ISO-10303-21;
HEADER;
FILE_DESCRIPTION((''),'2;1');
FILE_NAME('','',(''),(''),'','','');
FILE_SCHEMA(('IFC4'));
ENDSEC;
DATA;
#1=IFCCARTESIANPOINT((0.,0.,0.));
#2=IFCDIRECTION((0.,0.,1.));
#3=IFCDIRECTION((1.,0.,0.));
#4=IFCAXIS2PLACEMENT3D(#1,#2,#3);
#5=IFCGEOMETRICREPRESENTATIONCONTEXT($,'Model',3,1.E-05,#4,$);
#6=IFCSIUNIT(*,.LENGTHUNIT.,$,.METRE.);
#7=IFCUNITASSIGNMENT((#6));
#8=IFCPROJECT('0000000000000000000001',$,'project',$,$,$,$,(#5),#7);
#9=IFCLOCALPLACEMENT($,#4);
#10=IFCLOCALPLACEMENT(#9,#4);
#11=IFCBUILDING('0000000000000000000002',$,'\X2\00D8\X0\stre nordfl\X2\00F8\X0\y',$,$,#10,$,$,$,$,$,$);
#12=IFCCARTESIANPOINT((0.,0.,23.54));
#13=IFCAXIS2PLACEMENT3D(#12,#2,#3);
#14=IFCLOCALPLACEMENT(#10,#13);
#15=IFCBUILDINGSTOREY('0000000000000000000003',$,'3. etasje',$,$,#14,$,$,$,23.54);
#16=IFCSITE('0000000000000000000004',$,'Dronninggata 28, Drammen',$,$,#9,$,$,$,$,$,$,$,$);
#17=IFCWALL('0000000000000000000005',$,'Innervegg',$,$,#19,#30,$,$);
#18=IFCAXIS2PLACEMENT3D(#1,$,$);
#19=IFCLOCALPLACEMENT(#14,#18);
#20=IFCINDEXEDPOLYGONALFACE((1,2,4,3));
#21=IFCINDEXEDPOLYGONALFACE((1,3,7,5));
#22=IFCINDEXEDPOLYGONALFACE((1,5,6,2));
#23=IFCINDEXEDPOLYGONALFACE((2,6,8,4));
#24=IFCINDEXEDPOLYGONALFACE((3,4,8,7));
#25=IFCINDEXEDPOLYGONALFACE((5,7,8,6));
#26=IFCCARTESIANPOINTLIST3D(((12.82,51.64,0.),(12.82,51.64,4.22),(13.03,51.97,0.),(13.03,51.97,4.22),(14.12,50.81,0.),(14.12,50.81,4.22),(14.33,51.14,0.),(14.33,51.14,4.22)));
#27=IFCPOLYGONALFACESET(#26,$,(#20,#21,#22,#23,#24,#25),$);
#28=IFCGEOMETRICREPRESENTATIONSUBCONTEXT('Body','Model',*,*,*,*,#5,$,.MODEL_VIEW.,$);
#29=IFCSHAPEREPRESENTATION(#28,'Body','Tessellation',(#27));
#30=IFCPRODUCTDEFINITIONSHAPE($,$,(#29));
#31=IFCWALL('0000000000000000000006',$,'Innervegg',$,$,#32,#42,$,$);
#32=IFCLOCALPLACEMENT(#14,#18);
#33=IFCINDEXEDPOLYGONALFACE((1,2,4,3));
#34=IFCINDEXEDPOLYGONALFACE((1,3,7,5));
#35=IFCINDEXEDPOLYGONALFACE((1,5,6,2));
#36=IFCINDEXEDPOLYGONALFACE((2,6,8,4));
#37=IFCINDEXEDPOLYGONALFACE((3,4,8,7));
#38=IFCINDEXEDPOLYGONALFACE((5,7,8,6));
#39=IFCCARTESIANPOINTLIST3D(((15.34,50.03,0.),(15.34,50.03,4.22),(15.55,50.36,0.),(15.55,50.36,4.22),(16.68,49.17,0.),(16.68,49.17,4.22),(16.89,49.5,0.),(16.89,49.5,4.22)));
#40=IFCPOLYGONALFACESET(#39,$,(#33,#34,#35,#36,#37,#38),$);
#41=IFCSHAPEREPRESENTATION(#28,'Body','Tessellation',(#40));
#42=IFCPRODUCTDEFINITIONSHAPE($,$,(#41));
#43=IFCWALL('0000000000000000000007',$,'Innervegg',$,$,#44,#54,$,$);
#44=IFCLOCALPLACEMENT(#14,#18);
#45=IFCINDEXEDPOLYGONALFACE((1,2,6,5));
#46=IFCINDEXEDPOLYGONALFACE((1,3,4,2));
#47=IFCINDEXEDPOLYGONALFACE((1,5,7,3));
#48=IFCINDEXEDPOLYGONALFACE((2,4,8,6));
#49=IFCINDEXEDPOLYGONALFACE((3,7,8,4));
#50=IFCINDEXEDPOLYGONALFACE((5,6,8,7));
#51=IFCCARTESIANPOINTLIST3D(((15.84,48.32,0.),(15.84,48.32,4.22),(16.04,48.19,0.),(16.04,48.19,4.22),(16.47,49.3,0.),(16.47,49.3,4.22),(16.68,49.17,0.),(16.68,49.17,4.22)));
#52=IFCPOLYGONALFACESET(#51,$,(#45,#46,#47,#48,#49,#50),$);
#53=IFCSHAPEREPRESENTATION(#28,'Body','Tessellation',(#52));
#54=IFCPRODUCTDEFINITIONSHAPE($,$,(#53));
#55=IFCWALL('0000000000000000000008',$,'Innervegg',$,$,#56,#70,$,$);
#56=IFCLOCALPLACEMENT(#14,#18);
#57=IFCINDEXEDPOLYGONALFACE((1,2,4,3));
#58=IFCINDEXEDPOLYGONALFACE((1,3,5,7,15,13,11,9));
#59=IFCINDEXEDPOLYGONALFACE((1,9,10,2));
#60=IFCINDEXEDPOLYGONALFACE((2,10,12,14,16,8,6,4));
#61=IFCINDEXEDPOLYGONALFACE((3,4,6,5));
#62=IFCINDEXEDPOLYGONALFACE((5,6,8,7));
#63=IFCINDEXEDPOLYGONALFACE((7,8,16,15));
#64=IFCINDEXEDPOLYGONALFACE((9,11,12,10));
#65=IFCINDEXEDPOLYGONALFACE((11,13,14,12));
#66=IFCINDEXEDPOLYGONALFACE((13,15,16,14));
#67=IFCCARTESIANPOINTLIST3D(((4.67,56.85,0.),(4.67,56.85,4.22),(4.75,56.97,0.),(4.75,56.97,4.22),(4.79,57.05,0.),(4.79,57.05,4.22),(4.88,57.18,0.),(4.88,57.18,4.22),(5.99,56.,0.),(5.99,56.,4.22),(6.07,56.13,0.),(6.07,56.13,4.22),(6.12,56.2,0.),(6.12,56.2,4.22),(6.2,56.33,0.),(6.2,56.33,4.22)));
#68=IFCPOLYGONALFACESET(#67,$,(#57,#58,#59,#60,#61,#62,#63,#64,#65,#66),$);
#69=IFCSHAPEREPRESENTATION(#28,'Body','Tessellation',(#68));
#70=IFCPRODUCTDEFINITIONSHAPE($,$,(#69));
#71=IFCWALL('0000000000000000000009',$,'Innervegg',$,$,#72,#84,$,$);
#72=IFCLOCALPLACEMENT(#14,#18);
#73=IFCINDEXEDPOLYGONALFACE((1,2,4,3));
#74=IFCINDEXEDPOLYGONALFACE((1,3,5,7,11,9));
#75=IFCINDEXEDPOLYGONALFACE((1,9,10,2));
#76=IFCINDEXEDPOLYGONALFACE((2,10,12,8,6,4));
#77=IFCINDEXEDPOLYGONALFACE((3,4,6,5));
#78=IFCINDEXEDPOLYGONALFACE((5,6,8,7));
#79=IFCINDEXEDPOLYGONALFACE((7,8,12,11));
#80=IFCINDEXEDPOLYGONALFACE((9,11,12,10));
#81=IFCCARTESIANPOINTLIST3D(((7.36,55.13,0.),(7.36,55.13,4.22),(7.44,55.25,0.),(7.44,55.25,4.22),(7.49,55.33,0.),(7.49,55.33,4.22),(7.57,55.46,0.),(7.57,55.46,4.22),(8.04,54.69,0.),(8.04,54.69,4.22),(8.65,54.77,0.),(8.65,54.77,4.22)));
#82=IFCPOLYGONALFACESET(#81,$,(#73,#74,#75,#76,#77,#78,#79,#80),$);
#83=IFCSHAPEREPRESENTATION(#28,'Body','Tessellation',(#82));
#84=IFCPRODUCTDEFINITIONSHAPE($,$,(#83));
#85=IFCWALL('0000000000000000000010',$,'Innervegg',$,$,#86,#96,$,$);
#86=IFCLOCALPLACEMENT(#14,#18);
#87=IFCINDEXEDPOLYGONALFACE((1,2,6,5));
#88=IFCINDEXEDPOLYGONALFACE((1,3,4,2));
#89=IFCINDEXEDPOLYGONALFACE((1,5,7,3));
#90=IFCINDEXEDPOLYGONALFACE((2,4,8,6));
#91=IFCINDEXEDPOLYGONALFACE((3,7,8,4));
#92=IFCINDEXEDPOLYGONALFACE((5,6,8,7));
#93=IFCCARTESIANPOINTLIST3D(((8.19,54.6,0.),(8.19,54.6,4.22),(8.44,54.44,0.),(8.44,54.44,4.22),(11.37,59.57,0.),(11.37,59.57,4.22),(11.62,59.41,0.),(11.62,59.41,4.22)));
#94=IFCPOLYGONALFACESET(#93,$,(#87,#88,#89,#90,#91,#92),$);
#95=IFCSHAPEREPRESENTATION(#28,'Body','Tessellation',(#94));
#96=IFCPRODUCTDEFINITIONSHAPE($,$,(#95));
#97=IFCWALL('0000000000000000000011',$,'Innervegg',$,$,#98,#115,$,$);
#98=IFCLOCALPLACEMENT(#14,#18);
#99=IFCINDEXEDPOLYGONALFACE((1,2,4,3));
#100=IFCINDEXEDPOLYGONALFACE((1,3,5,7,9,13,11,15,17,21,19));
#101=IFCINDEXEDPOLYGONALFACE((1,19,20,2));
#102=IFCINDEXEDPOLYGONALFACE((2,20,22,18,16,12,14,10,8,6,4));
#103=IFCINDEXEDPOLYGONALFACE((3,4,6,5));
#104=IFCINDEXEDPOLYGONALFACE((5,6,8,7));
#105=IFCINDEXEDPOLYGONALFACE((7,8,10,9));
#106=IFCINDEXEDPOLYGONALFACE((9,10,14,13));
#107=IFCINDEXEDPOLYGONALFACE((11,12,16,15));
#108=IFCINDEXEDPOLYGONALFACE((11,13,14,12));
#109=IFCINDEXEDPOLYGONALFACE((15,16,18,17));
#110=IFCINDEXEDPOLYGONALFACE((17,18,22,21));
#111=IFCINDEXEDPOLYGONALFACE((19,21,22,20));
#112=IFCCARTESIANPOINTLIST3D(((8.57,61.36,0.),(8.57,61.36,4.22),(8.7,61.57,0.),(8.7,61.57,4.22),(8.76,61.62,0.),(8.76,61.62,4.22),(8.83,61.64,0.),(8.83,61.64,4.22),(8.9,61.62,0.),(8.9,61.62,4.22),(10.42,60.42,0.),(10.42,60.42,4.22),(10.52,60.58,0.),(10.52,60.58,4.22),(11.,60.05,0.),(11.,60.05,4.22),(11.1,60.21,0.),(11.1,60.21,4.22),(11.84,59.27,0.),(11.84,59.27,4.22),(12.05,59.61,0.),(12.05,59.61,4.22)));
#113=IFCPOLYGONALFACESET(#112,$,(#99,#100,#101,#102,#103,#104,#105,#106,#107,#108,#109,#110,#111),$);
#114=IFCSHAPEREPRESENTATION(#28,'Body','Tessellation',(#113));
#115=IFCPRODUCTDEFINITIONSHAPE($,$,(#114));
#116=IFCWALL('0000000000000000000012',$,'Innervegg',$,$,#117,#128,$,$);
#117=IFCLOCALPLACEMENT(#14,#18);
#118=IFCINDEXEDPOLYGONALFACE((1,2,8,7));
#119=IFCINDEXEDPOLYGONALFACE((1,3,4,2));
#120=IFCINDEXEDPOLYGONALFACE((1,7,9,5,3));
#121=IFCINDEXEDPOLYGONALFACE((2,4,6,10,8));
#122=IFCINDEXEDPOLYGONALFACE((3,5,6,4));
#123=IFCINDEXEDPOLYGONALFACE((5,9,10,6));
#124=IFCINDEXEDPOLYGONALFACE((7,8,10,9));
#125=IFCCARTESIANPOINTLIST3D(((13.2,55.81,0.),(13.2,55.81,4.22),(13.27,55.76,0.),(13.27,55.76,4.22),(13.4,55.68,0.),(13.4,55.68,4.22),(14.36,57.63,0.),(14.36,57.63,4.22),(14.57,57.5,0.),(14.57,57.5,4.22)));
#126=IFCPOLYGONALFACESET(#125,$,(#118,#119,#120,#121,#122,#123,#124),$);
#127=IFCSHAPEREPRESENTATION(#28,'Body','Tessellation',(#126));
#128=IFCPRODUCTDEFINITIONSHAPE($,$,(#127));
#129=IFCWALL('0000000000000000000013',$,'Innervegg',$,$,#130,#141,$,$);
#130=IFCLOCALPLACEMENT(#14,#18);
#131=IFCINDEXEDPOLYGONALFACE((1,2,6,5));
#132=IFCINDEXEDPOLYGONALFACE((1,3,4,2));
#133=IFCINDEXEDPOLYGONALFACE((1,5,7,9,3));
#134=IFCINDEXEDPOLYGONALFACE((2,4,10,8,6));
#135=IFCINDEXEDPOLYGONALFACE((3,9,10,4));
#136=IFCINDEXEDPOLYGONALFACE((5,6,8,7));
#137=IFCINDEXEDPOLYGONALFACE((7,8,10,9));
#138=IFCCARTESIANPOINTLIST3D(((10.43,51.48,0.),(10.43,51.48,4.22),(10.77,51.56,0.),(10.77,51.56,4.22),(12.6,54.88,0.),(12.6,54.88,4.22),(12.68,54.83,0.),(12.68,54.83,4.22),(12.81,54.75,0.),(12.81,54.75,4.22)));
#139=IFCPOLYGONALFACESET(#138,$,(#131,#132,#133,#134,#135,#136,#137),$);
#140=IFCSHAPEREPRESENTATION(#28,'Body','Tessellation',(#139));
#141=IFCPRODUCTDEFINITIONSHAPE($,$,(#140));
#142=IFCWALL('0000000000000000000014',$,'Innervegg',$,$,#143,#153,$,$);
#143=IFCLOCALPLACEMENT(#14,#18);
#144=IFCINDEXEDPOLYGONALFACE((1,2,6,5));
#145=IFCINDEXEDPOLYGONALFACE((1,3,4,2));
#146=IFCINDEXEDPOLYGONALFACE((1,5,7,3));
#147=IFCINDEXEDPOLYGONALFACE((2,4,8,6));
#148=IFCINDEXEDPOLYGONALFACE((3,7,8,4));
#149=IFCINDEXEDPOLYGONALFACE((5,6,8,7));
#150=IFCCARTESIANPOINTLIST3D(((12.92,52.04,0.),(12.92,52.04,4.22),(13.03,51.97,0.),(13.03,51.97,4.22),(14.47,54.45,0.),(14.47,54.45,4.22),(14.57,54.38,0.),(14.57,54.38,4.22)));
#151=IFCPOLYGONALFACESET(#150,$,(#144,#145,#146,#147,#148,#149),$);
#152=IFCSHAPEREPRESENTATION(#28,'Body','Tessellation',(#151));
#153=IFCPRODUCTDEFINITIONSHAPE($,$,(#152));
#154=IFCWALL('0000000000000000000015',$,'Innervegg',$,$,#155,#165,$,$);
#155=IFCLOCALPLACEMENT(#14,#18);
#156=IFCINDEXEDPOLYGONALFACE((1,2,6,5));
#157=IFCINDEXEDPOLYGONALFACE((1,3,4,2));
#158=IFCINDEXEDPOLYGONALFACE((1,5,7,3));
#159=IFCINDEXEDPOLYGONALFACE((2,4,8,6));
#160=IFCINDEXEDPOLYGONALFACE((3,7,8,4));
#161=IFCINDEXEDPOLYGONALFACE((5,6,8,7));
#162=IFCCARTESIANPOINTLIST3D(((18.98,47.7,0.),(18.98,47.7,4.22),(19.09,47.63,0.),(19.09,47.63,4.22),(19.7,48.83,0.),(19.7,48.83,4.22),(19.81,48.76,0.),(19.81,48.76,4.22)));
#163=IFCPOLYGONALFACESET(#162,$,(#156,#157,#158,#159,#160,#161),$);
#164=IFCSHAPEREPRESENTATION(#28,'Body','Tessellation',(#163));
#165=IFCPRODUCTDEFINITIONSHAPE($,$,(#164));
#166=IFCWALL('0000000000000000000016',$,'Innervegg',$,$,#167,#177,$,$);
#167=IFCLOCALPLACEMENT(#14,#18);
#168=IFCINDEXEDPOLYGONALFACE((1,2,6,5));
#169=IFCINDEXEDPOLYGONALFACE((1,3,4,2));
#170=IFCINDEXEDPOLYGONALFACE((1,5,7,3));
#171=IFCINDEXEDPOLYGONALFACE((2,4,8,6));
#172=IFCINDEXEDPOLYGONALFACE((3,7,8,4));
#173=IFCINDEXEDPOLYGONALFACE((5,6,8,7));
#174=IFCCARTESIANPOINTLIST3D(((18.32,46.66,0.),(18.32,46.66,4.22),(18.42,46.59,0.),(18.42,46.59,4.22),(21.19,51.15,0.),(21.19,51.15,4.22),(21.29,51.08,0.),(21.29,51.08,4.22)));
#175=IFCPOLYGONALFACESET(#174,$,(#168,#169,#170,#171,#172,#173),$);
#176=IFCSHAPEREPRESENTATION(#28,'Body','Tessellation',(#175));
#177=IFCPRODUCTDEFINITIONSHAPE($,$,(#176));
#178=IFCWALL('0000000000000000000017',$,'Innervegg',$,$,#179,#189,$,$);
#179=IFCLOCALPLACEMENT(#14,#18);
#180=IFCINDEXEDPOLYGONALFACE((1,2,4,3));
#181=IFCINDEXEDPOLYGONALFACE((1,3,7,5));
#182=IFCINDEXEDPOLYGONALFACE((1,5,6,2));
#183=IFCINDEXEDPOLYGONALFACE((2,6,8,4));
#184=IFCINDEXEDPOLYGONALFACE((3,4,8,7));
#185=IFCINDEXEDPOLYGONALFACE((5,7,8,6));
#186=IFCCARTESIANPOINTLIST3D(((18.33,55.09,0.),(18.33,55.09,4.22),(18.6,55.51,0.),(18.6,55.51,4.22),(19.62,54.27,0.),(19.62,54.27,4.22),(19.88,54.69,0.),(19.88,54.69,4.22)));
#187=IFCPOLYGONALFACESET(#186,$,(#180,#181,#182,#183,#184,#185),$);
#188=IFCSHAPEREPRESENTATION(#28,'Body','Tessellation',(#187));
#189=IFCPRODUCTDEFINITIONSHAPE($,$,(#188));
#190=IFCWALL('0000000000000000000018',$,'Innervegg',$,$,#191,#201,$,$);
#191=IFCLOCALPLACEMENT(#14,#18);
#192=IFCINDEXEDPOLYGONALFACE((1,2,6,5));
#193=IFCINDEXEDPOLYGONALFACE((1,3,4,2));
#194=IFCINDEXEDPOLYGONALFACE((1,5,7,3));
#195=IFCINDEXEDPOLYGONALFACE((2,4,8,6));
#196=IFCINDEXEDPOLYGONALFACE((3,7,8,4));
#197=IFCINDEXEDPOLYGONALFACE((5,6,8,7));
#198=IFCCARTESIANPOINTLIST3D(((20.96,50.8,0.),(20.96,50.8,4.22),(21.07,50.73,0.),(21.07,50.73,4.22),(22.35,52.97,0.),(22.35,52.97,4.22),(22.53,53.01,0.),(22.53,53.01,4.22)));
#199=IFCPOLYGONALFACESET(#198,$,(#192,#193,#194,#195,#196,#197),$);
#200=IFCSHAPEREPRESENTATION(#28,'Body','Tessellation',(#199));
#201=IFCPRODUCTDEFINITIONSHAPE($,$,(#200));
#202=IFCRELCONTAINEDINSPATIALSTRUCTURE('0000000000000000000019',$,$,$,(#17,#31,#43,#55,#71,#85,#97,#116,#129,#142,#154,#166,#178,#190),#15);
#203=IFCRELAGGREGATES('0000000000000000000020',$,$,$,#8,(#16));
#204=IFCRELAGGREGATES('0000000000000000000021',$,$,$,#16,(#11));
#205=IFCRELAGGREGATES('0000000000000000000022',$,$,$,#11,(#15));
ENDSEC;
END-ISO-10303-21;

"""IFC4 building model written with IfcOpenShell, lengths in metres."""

from ifc_helpers import new_model, si_unit, frame, origin_with_axes, place, context, subcontext, project, spatial, polyline, outline, extrude, element, save


model = new_model("IFC4")

# Units and contexts
model_context = context("Model", 3, precision=1e-05, world=origin_with_axes())
body_context = subcontext(model_context, "Body", "Model", "MODEL_VIEW")
ifc_project = project(units=[si_unit("LENGTHUNIT", "METRE")], contexts=[model_context])

# Site, building, storey
site_placement = place(None, origin_with_axes())
site = spatial("IfcSite", under=ifc_project, at=site_placement, Name="Dronninggata 28, Drammen")
building_placement = place(site_placement, origin_with_axes())
building = spatial("IfcBuilding", under=site, at=building_placement, Name="Østre nordfløy")
storey_placement = place(building_placement, frame((0.0, 0.0, 23.54), z_axis=(0.0, 0.0, 1.0), x_axis=(1.0, 0.0, 0.0)))
storey = spatial("IfcBuildingStorey", under=building, at=storey_placement, Name="3. etasje", Elevation=23.54)

# Walls
wall_1_placement = place(storey_placement, frame((0.0, 0.0, -23.54), z_axis=(0.0, 0.0, 1.0), x_axis=(1.0, 0.0, 0.0)))
element("IfcWall", 1, at=wall_1_placement, inside=storey, Name="Innervegg", context=body_context, shape_type="SweptSolid", body=[
    extrude(outline(polyline([(13.03, 51.97), (14.33, 51.14), (14.12, 50.81), (12.82, 51.64), (13.03, 51.97)])), frame((0.0, 0.0, 23.54)), (0.0, 0.0, 1.0), 4.22),
])
wall_2_placement = place(storey_placement, frame((0.0, 0.0, -23.54), z_axis=(0.0, 0.0, 1.0), x_axis=(1.0, 0.0, 0.0)))
element("IfcWall", 2, at=wall_2_placement, inside=storey, Name="Innervegg", context=body_context, shape_type="SweptSolid", body=[
    extrude(outline(polyline([(15.55, 50.36), (16.89, 49.5), (16.68, 49.17), (15.34, 50.03), (15.55, 50.36)])), frame((0.0, 0.0, 23.54)), (0.0, 0.0, 1.0), 4.22),
])
wall_3_placement = place(storey_placement, frame((0.0, 0.0, -23.54), z_axis=(0.0, 0.0, 1.0), x_axis=(1.0, 0.0, 0.0)))
element("IfcWall", 3, at=wall_3_placement, inside=storey, Name="Innervegg", context=body_context, shape_type="SweptSolid", body=[
    extrude(outline(polyline([(16.47, 49.3), (16.68, 49.17), (16.04, 48.19), (15.84, 48.32), (16.47, 49.3)])), frame((0.0, 0.0, 23.54)), (0.0, 0.0, 1.0), 4.22),
])
wall_4_placement = place(storey_placement, frame((0.0, 0.0, -23.54), z_axis=(0.0, 0.0, 1.0), x_axis=(1.0, 0.0, 0.0)))
element("IfcWall", 4, at=wall_4_placement, inside=storey, Name="Innervegg", context=body_context, shape_type="SweptSolid", body=[
    extrude(outline(polyline([(4.75, 56.97), (4.79, 57.05), (4.88, 57.18), (6.2, 56.33), (6.12, 56.2), (6.07, 56.13), (5.99, 56.0), (4.67, 56.85), (4.75, 56.97)])), frame((0.0, 0.0, 23.54)), (0.0, 0.0, 1.0), 4.22),
])
wall_5_placement = place(storey_placement, frame((0.0, 0.0, -23.54), z_axis=(0.0, 0.0, 1.0), x_axis=(1.0, 0.0, 0.0)))
element("IfcWall", 5, at=wall_5_placement, inside=storey, Name="Innervegg", context=body_context, shape_type="SweptSolid", body=[
    extrude(outline(polyline([(7.36, 55.13), (7.44, 55.25), (7.49, 55.33), (7.57, 55.46), (8.65, 54.77), (8.04, 54.69), (7.36, 55.13)])), frame((0.0, 0.0, 23.54)), (0.0, 0.0, 1.0), 4.22),
])
wall_6_placement = place(storey_placement, frame((0.0, 0.0, -23.54), z_axis=(0.0, 0.0, 1.0), x_axis=(1.0, 0.0, 0.0)))
element("IfcWall", 6, at=wall_6_placement, inside=storey, Name="Innervegg", context=body_context, shape_type="SweptSolid", body=[
    extrude(outline(polyline([(8.44, 54.44), (8.19, 54.6), (11.37, 59.57), (11.62, 59.41), (8.44, 54.44)])), frame((0.0, 0.0, 23.54)), (0.0, 0.0, 1.0), 4.22),
])
wall_7_placement = place(storey_placement, frame((0.0, 0.0, -23.54), z_axis=(0.0, 0.0, 1.0), x_axis=(1.0, 0.0, 0.0)))
element("IfcWall", 7, at=wall_7_placement, inside=storey, Name="Innervegg", context=body_context, shape_type="SweptSolid", body=[
    extrude(outline(polyline([(11.84, 59.27), (8.57, 61.36), (8.7, 61.57), (8.76, 61.62), (8.83, 61.64), (8.9, 61.62), (10.52, 60.58), (10.42, 60.42), (11.0, 60.05), (11.1, 60.21), (12.05, 59.61), (11.84, 59.27)])), frame((0.0, 0.0, 23.54)), (0.0, 0.0, 1.0), 4.22),
])
wall_8_placement = place(storey_placement, frame((0.0, 0.0, -23.54), z_axis=(0.0, 0.0, 1.0), x_axis=(1.0, 0.0, 0.0)))
element("IfcWall", 8, at=wall_8_placement, inside=storey, Name="Innervegg", context=body_context, shape_type="SweptSolid", body=[
    extrude(outline(polyline([(14.36, 57.63), (14.57, 57.5), (13.4, 55.68), (13.27, 55.76), (13.2, 55.81), (14.36, 57.63)])), frame((0.0, 0.0, 23.54)), (0.0, 0.0, 1.0), 4.22),
])
wall_9_placement = place(storey_placement, frame((0.0, 0.0, -23.54), z_axis=(0.0, 0.0, 1.0), x_axis=(1.0, 0.0, 0.0)))
element("IfcWall", 9, at=wall_9_placement, inside=storey, Name="Innervegg", context=body_context, shape_type="SweptSolid", body=[
    extrude(outline(polyline([(10.43, 51.48), (12.6, 54.88), (12.68, 54.83), (12.81, 54.75), (10.77, 51.56), (10.43, 51.48)])), frame((0.0, 0.0, 23.54)), (0.0, 0.0, 1.0), 4.22),
])
wall_10_placement = place(storey_placement, frame((0.0, 0.0, -23.54), z_axis=(0.0, 0.0, 1.0), x_axis=(1.0, 0.0, 0.0)))
element("IfcWall", 10, at=wall_10_placement, inside=storey, Name="Innervegg", context=body_context, shape_type="SweptSolid", body=[
    extrude(outline(polyline([(14.47, 54.45), (14.57, 54.38), (13.03, 51.97), (12.92, 52.04), (14.47, 54.45)])), frame((0.0, 0.0, 23.54)), (0.0, 0.0, 1.0), 4.22),
])
wall_11_placement = place(storey_placement, frame((0.0, 0.0, -23.54), z_axis=(0.0, 0.0, 1.0), x_axis=(1.0, 0.0, 0.0)))
element("IfcWall", 11, at=wall_11_placement, inside=storey, Name="Innervegg", context=body_context, shape_type="SweptSolid", body=[
    extrude(outline(polyline([(19.09, 47.63), (18.98, 47.7), (19.7, 48.83), (19.81, 48.76), (19.09, 47.63)])), frame((0.0, 0.0, 23.54)), (0.0, 0.0, 1.0), 4.22),
])
wall_12_placement = place(storey_placement, frame((0.0, 0.0, -23.54), z_axis=(0.0, 0.0, 1.0), x_axis=(1.0, 0.0, 0.0)))
element("IfcWall", 12, at=wall_12_placement, inside=storey, Name="Innervegg", context=body_context, shape_type="SweptSolid", body=[
    extrude(outline(polyline([(18.42, 46.59), (18.32, 46.66), (21.19, 51.15), (21.29, 51.08), (18.42, 46.59)])), frame((0.0, 0.0, 23.54)), (0.0, 0.0, 1.0), 4.22),
])
wall_13_placement = place(storey_placement, frame((0.0, 0.0, -23.54), z_axis=(0.0, 0.0, 1.0), x_axis=(1.0, 0.0, 0.0)))
element("IfcWall", 13, at=wall_13_placement, inside=storey, Name="Innervegg", context=body_context, shape_type="SweptSolid", body=[
    extrude(outline(polyline([(19.62, 54.27), (18.33, 55.09), (18.6, 55.51), (19.88, 54.69), (19.62, 54.27)])), frame((0.0, 0.0, 23.54)), (0.0, 0.0, 1.0), 4.22),
])
wall_14_placement = place(storey_placement, frame((0.0, 0.0, -23.54), z_axis=(0.0, 0.0, 1.0), x_axis=(1.0, 0.0, 0.0)))
element("IfcWall", 14, at=wall_14_placement, inside=storey, Name="Innervegg", context=body_context, shape_type="SweptSolid", body=[
    extrude(outline(polyline([(21.07, 50.73), (20.96, 50.8), (22.35, 52.97), (22.53, 53.01), (21.07, 50.73)])), frame((0.0, 0.0, 23.54)), (0.0, 0.0, 1.0), 4.22),
])

save(model, "model.ifc")
